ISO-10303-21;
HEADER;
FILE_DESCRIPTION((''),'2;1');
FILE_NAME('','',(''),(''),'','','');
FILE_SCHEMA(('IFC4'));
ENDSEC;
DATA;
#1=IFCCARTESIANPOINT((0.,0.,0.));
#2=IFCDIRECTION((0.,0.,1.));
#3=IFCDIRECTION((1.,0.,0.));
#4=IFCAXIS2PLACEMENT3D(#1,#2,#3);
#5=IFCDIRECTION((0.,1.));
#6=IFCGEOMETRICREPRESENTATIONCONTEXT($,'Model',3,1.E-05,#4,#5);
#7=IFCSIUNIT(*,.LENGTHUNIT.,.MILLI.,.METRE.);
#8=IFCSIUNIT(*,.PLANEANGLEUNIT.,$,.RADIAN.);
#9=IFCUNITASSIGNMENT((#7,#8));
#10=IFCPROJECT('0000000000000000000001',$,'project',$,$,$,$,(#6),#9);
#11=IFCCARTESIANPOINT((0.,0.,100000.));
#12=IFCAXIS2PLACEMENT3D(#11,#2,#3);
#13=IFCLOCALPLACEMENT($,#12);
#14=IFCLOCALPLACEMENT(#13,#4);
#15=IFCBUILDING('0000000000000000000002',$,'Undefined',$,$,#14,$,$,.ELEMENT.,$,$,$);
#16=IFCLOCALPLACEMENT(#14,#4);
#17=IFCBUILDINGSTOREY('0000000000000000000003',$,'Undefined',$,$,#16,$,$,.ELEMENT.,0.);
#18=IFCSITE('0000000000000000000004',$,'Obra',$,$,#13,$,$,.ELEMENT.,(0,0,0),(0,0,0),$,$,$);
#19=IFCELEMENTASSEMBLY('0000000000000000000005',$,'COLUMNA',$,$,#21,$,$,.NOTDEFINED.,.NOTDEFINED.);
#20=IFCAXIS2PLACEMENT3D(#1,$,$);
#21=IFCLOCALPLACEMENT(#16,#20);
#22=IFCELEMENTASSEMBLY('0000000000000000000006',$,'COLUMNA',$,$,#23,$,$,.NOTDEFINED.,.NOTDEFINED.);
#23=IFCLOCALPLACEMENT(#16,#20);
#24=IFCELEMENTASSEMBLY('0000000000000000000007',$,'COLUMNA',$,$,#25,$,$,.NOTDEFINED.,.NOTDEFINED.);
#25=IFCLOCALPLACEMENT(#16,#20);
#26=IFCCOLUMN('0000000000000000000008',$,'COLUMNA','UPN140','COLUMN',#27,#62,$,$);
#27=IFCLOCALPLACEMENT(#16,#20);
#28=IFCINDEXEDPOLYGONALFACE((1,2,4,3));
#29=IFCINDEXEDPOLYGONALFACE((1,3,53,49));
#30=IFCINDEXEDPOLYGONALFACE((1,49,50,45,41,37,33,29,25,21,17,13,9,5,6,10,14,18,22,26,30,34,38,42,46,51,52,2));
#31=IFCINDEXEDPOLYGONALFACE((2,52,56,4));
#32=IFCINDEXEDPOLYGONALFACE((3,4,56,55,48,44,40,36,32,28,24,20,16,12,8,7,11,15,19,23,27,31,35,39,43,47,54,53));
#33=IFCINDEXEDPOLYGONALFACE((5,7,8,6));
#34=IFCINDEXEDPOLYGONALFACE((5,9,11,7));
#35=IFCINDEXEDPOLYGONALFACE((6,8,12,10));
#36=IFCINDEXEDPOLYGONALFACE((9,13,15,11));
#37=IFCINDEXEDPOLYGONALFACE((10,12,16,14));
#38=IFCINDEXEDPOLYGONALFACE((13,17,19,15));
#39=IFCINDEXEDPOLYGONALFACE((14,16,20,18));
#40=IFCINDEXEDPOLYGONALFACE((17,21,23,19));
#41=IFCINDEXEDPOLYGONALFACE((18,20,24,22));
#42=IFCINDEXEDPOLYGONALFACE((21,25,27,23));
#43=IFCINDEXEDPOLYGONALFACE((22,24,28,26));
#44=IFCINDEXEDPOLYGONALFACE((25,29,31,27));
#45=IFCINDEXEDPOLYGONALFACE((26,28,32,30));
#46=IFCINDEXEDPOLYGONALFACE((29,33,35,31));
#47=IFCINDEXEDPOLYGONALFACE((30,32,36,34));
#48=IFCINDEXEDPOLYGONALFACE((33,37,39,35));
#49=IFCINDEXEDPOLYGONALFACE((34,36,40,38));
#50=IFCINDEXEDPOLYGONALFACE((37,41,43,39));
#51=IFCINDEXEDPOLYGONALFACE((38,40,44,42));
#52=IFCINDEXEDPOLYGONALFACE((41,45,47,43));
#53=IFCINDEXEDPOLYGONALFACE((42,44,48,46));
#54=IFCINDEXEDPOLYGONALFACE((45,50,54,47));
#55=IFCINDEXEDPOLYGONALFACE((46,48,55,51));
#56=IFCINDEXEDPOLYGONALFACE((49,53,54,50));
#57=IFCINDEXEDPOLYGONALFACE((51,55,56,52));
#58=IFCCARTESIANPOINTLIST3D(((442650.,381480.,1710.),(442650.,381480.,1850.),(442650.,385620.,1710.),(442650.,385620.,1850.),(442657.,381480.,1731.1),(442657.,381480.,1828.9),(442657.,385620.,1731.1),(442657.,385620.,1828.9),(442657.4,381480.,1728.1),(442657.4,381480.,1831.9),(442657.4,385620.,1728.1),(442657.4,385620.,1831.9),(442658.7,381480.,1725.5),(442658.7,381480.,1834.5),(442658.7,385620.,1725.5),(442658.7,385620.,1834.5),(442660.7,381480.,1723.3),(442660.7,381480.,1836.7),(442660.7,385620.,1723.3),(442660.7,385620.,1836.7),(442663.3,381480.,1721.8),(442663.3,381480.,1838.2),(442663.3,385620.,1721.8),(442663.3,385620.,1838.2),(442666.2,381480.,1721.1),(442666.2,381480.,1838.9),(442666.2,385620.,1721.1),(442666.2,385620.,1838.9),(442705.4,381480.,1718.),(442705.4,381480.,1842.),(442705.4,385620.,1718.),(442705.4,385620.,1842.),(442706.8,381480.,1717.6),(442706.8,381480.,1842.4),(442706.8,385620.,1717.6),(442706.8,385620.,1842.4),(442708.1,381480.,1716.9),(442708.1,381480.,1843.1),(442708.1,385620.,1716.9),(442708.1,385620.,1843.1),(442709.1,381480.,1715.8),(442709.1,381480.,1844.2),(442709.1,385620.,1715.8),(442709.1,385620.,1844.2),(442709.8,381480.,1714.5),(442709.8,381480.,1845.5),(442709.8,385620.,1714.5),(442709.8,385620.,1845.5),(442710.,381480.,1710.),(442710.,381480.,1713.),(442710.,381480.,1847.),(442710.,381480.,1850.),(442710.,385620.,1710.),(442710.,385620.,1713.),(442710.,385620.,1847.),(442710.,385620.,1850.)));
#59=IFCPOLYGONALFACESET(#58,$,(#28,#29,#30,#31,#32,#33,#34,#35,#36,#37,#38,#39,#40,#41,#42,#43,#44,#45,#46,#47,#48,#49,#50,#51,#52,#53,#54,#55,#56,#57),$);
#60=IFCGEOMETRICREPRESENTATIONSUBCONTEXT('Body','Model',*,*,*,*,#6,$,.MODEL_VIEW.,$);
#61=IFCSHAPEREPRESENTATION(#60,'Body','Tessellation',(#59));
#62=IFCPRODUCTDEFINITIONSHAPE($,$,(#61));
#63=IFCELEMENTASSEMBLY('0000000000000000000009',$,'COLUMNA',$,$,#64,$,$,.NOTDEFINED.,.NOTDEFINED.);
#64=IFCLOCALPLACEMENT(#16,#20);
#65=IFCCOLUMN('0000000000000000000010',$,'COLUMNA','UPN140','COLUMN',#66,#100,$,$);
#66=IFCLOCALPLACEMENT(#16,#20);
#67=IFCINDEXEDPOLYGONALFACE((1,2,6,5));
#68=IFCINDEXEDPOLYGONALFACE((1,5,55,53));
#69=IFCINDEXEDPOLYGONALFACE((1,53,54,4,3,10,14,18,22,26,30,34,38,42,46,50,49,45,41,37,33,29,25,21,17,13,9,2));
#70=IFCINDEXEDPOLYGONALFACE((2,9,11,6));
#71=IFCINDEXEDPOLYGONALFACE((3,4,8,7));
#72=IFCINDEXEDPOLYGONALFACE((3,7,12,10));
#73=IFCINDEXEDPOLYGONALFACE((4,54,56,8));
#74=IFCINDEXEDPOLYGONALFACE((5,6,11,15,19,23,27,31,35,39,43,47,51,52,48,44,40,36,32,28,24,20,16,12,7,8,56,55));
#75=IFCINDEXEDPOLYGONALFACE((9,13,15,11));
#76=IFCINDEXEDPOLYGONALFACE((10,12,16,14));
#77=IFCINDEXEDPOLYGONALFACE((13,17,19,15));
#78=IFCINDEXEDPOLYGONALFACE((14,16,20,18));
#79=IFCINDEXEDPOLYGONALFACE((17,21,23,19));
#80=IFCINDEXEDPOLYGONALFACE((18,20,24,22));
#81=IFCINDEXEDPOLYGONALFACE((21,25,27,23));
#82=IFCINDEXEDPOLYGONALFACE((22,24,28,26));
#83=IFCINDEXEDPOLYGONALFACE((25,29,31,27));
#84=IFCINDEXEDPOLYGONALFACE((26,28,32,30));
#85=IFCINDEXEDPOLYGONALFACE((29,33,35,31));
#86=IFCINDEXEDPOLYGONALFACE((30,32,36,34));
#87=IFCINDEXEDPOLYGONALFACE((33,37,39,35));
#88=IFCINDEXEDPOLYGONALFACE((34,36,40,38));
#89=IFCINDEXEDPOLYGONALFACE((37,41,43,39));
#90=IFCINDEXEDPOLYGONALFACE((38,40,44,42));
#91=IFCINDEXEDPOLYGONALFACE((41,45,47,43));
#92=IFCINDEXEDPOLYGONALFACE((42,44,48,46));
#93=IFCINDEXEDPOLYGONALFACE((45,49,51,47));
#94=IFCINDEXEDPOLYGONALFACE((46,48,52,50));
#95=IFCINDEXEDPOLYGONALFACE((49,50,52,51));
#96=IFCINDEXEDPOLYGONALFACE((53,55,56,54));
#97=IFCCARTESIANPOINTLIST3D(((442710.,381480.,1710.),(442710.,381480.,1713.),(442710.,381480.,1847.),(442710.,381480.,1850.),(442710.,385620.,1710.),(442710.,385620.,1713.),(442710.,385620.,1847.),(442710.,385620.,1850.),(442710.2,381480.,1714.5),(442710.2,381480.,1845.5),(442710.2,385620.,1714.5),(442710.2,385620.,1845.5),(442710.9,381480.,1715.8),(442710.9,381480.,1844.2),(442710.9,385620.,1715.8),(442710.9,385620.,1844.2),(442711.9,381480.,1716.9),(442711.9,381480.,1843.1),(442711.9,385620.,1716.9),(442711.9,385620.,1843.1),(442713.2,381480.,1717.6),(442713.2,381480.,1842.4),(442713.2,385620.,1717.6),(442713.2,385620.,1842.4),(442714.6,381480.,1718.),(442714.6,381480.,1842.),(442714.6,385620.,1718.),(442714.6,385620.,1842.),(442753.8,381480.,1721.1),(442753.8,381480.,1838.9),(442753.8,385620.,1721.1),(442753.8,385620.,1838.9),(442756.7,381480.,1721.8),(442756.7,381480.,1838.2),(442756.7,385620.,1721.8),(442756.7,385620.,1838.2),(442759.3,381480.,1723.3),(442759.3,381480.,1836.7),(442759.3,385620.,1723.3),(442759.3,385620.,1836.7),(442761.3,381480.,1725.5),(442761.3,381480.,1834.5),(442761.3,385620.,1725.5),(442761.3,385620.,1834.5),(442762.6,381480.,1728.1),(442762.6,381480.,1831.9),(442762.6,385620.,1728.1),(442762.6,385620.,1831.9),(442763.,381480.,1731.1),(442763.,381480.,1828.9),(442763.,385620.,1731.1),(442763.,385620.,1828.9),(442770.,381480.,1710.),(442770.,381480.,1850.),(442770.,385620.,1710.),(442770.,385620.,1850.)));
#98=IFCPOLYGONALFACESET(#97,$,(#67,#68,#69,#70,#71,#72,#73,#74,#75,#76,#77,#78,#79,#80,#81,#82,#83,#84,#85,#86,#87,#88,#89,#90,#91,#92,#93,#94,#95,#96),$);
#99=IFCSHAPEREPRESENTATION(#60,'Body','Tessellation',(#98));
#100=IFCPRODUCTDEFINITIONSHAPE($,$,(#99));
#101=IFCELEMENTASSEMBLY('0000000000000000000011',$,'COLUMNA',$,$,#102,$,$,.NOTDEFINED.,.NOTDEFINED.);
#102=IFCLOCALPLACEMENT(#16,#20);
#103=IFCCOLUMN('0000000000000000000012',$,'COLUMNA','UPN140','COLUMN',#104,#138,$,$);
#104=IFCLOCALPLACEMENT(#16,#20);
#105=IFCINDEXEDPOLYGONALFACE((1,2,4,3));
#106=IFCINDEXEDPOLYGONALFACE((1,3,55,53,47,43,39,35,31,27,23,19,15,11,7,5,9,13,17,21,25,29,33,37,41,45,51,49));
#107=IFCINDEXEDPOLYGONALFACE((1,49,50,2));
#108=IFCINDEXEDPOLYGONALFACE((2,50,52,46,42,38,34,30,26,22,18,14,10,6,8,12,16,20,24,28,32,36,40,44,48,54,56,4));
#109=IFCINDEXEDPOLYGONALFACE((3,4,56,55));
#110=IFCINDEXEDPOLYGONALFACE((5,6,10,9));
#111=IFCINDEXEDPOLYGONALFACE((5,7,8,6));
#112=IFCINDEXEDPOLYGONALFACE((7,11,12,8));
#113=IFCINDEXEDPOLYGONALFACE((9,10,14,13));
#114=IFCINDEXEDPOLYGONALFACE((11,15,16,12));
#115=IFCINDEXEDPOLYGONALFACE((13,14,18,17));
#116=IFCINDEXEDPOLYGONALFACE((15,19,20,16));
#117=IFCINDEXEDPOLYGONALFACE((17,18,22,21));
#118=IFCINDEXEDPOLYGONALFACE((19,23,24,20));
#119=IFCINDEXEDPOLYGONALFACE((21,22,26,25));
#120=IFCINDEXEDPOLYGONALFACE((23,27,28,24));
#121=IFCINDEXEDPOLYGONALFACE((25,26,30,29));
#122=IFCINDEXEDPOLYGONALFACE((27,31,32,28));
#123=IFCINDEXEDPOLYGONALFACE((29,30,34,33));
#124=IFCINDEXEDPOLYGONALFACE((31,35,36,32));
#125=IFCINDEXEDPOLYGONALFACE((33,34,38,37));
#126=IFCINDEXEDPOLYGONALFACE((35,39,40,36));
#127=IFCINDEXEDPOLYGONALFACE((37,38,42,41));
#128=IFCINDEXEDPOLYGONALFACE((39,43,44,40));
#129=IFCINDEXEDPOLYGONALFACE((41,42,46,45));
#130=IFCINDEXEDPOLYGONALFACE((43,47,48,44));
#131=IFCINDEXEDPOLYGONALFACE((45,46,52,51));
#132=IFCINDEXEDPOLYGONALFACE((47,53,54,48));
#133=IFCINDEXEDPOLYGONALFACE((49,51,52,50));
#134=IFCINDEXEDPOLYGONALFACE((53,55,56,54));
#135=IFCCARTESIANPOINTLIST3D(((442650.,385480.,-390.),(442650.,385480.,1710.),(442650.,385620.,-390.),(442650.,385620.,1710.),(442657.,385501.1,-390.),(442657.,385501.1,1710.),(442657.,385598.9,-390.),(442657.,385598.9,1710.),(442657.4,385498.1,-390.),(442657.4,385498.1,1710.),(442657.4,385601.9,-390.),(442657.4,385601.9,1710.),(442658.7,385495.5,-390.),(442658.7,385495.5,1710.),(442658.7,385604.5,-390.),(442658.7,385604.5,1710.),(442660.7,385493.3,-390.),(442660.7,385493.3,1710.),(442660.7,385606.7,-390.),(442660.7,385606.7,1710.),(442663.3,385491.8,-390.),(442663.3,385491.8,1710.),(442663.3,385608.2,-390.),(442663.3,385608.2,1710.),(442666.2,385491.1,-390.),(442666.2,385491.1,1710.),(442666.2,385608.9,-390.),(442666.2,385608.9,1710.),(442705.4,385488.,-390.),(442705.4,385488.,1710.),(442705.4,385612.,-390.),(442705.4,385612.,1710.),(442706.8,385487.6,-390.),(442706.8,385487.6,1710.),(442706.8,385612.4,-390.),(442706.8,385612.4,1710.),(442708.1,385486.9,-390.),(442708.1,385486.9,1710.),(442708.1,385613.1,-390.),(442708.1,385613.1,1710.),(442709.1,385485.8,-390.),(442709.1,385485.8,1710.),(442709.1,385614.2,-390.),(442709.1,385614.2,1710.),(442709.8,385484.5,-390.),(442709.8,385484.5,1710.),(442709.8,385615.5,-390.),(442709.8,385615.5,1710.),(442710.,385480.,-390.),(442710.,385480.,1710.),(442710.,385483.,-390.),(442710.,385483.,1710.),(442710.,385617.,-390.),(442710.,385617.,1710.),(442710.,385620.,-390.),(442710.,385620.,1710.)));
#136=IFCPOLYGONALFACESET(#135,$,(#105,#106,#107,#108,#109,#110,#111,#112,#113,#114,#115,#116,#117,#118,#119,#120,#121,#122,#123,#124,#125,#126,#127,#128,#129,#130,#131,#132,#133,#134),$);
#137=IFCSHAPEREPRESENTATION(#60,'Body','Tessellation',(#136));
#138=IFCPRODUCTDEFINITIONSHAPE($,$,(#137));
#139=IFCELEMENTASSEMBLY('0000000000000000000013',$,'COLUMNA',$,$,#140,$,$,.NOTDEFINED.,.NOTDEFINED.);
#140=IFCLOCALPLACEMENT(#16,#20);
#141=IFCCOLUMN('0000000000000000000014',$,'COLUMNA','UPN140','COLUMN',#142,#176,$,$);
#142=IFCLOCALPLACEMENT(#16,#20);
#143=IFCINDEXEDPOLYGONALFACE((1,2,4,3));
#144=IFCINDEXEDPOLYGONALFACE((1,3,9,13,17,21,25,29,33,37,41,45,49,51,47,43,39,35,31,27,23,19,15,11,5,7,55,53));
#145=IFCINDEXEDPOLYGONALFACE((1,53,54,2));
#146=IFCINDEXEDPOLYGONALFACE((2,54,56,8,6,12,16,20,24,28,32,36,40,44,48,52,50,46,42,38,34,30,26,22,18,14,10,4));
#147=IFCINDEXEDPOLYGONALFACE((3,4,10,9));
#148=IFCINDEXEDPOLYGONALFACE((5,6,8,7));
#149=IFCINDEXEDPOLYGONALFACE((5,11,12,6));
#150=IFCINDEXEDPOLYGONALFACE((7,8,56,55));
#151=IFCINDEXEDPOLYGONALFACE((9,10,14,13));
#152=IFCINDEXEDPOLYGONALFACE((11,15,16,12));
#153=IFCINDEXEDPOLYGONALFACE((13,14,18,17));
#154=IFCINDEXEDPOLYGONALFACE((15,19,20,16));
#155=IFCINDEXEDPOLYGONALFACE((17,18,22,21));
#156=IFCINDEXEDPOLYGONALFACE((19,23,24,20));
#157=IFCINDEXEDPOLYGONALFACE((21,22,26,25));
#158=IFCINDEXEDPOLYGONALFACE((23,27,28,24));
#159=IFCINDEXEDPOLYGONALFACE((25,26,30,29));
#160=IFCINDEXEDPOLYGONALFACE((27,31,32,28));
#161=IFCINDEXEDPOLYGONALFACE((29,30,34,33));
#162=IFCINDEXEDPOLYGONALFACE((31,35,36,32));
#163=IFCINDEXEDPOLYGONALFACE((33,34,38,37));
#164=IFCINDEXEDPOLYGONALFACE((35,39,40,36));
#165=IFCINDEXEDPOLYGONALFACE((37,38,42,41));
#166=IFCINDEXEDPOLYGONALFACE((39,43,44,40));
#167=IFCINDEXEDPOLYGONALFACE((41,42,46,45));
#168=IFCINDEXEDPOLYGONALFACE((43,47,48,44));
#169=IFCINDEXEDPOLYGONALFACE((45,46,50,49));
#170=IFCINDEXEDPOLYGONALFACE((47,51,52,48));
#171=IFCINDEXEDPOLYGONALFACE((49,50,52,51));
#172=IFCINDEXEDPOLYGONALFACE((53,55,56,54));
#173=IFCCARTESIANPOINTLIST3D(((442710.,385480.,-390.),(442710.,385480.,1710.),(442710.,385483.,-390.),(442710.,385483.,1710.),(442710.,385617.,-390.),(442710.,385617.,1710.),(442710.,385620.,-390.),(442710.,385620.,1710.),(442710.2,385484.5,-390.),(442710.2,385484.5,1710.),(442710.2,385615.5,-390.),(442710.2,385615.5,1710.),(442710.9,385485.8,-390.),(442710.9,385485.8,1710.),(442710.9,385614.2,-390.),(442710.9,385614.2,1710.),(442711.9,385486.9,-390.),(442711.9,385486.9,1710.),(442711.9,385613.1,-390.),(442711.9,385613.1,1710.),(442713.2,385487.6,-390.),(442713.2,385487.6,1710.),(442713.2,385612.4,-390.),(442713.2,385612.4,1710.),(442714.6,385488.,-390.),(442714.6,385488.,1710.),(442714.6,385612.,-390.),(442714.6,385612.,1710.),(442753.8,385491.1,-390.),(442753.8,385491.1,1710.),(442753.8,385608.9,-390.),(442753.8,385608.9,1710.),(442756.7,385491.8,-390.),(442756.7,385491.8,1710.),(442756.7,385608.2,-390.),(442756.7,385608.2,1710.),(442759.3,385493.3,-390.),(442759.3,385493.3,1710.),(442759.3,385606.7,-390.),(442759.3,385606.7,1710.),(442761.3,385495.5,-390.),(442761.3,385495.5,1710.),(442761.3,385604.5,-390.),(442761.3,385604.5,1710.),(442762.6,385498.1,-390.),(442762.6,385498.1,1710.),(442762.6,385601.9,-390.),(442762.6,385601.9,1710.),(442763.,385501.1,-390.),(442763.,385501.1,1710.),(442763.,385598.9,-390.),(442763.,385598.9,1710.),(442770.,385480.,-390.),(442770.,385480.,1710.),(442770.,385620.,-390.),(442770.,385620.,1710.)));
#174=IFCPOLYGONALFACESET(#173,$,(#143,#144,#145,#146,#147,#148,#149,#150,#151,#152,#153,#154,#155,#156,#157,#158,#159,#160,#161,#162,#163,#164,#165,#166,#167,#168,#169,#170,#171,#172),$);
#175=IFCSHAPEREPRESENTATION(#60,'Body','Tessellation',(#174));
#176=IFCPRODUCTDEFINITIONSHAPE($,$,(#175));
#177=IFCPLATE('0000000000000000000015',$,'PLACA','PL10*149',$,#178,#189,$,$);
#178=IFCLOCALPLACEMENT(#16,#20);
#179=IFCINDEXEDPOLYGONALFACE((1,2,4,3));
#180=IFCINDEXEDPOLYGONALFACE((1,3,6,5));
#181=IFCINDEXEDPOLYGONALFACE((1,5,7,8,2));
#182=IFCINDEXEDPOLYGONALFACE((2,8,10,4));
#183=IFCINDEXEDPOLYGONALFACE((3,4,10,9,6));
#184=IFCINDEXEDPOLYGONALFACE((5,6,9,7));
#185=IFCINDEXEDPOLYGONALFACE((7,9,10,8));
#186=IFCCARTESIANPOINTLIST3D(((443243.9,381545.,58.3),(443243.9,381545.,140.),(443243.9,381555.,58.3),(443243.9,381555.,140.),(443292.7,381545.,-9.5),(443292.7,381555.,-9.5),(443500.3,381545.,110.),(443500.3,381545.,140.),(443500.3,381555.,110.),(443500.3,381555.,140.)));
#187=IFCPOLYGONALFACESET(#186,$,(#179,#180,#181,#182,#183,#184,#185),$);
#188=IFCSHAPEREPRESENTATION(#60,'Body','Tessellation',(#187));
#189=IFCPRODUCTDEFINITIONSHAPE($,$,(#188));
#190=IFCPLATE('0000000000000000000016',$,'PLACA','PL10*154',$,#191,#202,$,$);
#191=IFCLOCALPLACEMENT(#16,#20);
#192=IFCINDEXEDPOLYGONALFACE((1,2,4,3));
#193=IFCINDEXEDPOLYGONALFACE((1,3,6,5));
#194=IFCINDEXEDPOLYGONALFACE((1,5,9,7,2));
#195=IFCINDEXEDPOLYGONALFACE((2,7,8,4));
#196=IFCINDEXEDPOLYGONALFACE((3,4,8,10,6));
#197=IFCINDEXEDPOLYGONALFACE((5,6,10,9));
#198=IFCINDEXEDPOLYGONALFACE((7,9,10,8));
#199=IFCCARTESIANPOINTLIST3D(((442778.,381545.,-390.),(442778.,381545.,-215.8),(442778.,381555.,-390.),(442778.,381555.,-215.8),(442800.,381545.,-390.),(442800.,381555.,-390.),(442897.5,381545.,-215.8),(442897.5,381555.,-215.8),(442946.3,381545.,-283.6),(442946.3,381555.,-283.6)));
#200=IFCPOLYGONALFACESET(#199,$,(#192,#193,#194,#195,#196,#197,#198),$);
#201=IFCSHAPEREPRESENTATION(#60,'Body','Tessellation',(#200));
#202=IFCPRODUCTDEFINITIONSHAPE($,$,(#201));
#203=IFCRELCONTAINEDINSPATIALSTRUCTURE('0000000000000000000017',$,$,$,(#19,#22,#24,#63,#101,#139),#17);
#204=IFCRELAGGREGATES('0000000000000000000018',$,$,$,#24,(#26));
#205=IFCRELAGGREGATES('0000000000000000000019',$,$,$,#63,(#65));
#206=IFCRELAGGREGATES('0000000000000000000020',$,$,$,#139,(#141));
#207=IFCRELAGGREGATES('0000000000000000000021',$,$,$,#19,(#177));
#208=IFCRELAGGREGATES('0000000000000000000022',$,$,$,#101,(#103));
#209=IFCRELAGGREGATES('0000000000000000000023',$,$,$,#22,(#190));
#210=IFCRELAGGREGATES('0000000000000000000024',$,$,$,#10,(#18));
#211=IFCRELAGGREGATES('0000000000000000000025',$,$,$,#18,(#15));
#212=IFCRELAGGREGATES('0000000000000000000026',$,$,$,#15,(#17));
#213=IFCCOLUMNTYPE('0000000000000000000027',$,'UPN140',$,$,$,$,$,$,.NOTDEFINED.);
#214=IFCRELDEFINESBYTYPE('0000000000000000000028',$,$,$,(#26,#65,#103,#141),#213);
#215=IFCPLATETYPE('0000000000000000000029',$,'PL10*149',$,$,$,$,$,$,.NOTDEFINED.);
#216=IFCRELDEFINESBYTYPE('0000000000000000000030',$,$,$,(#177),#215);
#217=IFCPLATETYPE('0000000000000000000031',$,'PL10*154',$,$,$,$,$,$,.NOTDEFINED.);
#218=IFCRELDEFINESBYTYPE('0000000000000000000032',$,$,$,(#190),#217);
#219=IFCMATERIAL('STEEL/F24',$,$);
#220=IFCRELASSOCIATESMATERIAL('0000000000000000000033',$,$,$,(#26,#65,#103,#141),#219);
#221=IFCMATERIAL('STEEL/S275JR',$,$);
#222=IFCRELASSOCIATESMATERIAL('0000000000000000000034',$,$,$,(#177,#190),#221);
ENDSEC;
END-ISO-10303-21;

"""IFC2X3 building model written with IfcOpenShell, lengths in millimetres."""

from ifc_helpers import new_model, si_unit, direction, frame, origin_with_axes, origin_2d_with_axis, place, context, subcontext, project, spatial, polyline, u_section, outline, extrude, material, type_object, element, aggregate, save


model = new_model("IFC2X3")

# Units and contexts
model_context = context("Model", 3, precision=1e-05, world=origin_with_axes(), true_north=direction((0.0, 1.0)))
body_context = subcontext(model_context, "Body", "Model", "MODEL_VIEW")
ifc_project = project(units=[si_unit("LENGTHUNIT", "METRE", prefix="MILLI"), si_unit("PLANEANGLEUNIT", "RADIAN")], contexts=[model_context])

# Site, building, storey
site_placement = place(None, frame((0.0, 0.0, 100000.0), z_axis=(0.0, 0.0, 1.0), x_axis=(1.0, 0.0, 0.0)))
site = spatial("IfcSite", under=ifc_project, at=site_placement, Name="Obra", CompositionType="ELEMENT", RefLatitude=(0, 0, 0), RefLongitude=(0, 0, 0))
building_placement = place(site_placement, origin_with_axes())
building = spatial("IfcBuilding", under=site, at=building_placement, Name="Undefined", CompositionType="ELEMENT")
storey_placement = place(building_placement, origin_with_axes())
storey = spatial("IfcBuildingStorey", under=building, at=storey_placement, Name="Undefined", CompositionType="ELEMENT", Elevation=0.0)

# Element assemblies, columns
ifc_material_1 = material(Name="STEEL/F24")
assembly_1_placement = place(storey_placement, origin_with_axes())
assembly_1 = element("IfcElementAssembly", 1, at=assembly_1_placement, inside=storey, Name="COLUMNA", AssemblyPlace="NOTDEFINED", PredefinedType="NOTDEFINED")
column_type_1 = type_object("IfcColumnType", Name="UPN140", PredefinedType="NOTDEFINED")
assembly_2_placement = place(storey_placement, origin_with_axes())
assembly_2 = element("IfcElementAssembly", 2, at=assembly_2_placement, inside=storey, Name="COLUMNA", AssemblyPlace="NOTDEFINED", PredefinedType="NOTDEFINED")
assembly_3_placement = place(storey_placement, origin_with_axes())
assembly_3 = element("IfcElementAssembly", 3, at=assembly_3_placement, inside=storey, Name="COLUMNA", AssemblyPlace="NOTDEFINED", PredefinedType="NOTDEFINED")
column_1_placement = place(assembly_3_placement, frame((442680.0, 385620.0, 1780.0), z_axis=(0.0, -1.0, 0.0), x_axis=(0.0, 0.0, -1.0)))
column_1 = element("IfcColumn", 4, at=column_1_placement, type_object=column_type_1, material=ifc_material_1, Name="COLUMNA", Description="UPN140", ObjectType="COLUMN", context=body_context, shape_type="SweptSolid", body=[
    extrude(u_section(Depth=140.0, FlangeWidth=60.0, WebThickness=7.0, FlangeThickness=10.0, FilletRadius=10.0, EdgeRadius=5.0, FlangeSlope=0.07983, at=origin_2d_with_axis()), frame((0.0, 0.0, 4140.0), z_axis=(0.0, 0.0, -1.0), x_axis=(0.0, 1.0, 0.0)), (0.0, 0.0, 1.0), 4140.0),
])
aggregate(assembly_3, [column_1])
assembly_4_placement = place(storey_placement, origin_with_axes())
assembly_4 = element("IfcElementAssembly", 5, at=assembly_4_placement, inside=storey, Name="COLUMNA", AssemblyPlace="NOTDEFINED", PredefinedType="NOTDEFINED")
column_2_placement = place(assembly_4_placement, frame((442740.0, 385620.0, 1780.0), z_axis=(0.0, -1.0, 0.0), x_axis=(0.0, 0.0, 1.0)))
column_2 = element("IfcColumn", 6, at=column_2_placement, type_object=column_type_1, material=ifc_material_1, Name="COLUMNA", Description="UPN140", ObjectType="COLUMN", context=body_context, shape_type="SweptSolid", body=[
    extrude(u_section(Depth=140.0, FlangeWidth=60.0, WebThickness=7.0, FlangeThickness=10.0, FilletRadius=10.0, EdgeRadius=5.0, FlangeSlope=0.07983, at=origin_2d_with_axis()), frame((0.0, 0.0, 4140.0), z_axis=(0.0, 0.0, -1.0), x_axis=(0.0, 1.0, 0.0)), (0.0, 0.0, 1.0), 4140.0),
])
aggregate(assembly_4, [column_2])
assembly_5_placement = place(storey_placement, origin_with_axes())
assembly_5 = element("IfcElementAssembly", 7, at=assembly_5_placement, inside=storey, Name="COLUMNA", AssemblyPlace="NOTDEFINED", PredefinedType="NOTDEFINED")
column_3_placement = place(assembly_5_placement, frame((442680.0, 385550.0, -390.0), z_axis=(0.0, 0.0, 1.0), x_axis=(0.0, -1.0, 0.0)))
column_3 = element("IfcColumn", 8, at=column_3_placement, type_object=column_type_1, material=ifc_material_1, Name="COLUMNA", Description="UPN140", ObjectType="COLUMN", context=body_context, shape_type="SweptSolid", body=[
    extrude(u_section(Depth=140.0, FlangeWidth=60.0, WebThickness=7.0, FlangeThickness=10.0, FilletRadius=10.0, EdgeRadius=5.0, FlangeSlope=0.07983, at=origin_2d_with_axis()), frame((0.0, 0.0, 2100.0), z_axis=(0.0, 0.0, -1.0), x_axis=(0.0, 1.0, 0.0)), (0.0, 0.0, 1.0), 2100.0),
])
assembly_6_placement = place(storey_placement, origin_with_axes())
assembly_6 = element("IfcElementAssembly", 9, at=assembly_6_placement, inside=storey, Name="COLUMNA", AssemblyPlace="NOTDEFINED", PredefinedType="NOTDEFINED")
column_4_placement = place(assembly_6_placement, frame((442740.0, 385550.0, -390.0), z_axis=(0.0, 0.0, 1.0), x_axis=(0.0, 1.0, 0.0)))
column_4 = element("IfcColumn", 10, at=column_4_placement, type_object=column_type_1, material=ifc_material_1, Name="COLUMNA", Description="UPN140", ObjectType="COLUMN", context=body_context, shape_type="SweptSolid", body=[
    extrude(u_section(Depth=140.0, FlangeWidth=60.0, WebThickness=7.0, FlangeThickness=10.0, FilletRadius=10.0, EdgeRadius=5.0, FlangeSlope=0.07983, at=origin_2d_with_axis()), frame((0.0, 0.0, 2100.0), z_axis=(0.0, 0.0, -1.0), x_axis=(0.0, 1.0, 0.0)), (0.0, 0.0, 1.0), 2100.0),
])
aggregate(assembly_6, [column_4])

# Plates
ifc_material_2 = material(Name="STEEL/S275JR")
plate_type_1 = type_object("IfcPlateType", Name="PL10*149", PredefinedType="NOTDEFINED")
plate_1_placement = place(assembly_1_placement, frame((443500.3, 381550.0, 140.0), z_axis=(0.0, -1.0, 0.0), x_axis=(-1.0, 0.0, 0.0)))
plate_1 = element("IfcPlate", 11, at=plate_1_placement, type_object=plate_type_1, material=ifc_material_2, Name="PLACA", Description="PL10*149", context=body_context, shape_type="SweptSolid", body=[
    extrude(outline(polyline([(0.0, 0.0), (256.4, 0.0), (256.4, 81.7), (207.6, 149.5), (0.0, 30.0), (0.0, 0.0)])), frame((0.0, 0.0, -5.0), z_axis=(0.0, 0.0, 1.0), x_axis=(1.0, 0.0, 0.0)), (0.0, 0.0, 1.0), 10.0),
])
aggregate(assembly_1, [plate_1])
plate_type_2 = type_object("IfcPlateType", Name="PL10*154", PredefinedType="NOTDEFINED")
plate_2_placement = place(assembly_2_placement, frame((442778.0, 381550.0, -215.8), z_axis=(0.0, -1.0, 0.0), x_axis=(0.0, 0.0, -1.0)))
plate_2 = element("IfcPlate", 12, at=plate_2_placement, type_object=plate_type_2, material=ifc_material_2, Name="PLACA", Description="PL10*154", context=body_context, shape_type="SweptSolid", body=[
    extrude(outline(polyline([(0.0, 0.0), (174.2, 0.0), (174.2, 22.0), (67.8, 168.3), (0.0, 119.5), (0.0, 0.0)])), frame((0.0, 0.0, -5.0), z_axis=(0.0, 0.0, 1.0), x_axis=(1.0, 0.0, 0.0)), (0.0, 0.0, 1.0), 10.0),
])
aggregate(assembly_5, [column_3])
aggregate(assembly_2, [plate_2])

save(model, "model.ifc")
